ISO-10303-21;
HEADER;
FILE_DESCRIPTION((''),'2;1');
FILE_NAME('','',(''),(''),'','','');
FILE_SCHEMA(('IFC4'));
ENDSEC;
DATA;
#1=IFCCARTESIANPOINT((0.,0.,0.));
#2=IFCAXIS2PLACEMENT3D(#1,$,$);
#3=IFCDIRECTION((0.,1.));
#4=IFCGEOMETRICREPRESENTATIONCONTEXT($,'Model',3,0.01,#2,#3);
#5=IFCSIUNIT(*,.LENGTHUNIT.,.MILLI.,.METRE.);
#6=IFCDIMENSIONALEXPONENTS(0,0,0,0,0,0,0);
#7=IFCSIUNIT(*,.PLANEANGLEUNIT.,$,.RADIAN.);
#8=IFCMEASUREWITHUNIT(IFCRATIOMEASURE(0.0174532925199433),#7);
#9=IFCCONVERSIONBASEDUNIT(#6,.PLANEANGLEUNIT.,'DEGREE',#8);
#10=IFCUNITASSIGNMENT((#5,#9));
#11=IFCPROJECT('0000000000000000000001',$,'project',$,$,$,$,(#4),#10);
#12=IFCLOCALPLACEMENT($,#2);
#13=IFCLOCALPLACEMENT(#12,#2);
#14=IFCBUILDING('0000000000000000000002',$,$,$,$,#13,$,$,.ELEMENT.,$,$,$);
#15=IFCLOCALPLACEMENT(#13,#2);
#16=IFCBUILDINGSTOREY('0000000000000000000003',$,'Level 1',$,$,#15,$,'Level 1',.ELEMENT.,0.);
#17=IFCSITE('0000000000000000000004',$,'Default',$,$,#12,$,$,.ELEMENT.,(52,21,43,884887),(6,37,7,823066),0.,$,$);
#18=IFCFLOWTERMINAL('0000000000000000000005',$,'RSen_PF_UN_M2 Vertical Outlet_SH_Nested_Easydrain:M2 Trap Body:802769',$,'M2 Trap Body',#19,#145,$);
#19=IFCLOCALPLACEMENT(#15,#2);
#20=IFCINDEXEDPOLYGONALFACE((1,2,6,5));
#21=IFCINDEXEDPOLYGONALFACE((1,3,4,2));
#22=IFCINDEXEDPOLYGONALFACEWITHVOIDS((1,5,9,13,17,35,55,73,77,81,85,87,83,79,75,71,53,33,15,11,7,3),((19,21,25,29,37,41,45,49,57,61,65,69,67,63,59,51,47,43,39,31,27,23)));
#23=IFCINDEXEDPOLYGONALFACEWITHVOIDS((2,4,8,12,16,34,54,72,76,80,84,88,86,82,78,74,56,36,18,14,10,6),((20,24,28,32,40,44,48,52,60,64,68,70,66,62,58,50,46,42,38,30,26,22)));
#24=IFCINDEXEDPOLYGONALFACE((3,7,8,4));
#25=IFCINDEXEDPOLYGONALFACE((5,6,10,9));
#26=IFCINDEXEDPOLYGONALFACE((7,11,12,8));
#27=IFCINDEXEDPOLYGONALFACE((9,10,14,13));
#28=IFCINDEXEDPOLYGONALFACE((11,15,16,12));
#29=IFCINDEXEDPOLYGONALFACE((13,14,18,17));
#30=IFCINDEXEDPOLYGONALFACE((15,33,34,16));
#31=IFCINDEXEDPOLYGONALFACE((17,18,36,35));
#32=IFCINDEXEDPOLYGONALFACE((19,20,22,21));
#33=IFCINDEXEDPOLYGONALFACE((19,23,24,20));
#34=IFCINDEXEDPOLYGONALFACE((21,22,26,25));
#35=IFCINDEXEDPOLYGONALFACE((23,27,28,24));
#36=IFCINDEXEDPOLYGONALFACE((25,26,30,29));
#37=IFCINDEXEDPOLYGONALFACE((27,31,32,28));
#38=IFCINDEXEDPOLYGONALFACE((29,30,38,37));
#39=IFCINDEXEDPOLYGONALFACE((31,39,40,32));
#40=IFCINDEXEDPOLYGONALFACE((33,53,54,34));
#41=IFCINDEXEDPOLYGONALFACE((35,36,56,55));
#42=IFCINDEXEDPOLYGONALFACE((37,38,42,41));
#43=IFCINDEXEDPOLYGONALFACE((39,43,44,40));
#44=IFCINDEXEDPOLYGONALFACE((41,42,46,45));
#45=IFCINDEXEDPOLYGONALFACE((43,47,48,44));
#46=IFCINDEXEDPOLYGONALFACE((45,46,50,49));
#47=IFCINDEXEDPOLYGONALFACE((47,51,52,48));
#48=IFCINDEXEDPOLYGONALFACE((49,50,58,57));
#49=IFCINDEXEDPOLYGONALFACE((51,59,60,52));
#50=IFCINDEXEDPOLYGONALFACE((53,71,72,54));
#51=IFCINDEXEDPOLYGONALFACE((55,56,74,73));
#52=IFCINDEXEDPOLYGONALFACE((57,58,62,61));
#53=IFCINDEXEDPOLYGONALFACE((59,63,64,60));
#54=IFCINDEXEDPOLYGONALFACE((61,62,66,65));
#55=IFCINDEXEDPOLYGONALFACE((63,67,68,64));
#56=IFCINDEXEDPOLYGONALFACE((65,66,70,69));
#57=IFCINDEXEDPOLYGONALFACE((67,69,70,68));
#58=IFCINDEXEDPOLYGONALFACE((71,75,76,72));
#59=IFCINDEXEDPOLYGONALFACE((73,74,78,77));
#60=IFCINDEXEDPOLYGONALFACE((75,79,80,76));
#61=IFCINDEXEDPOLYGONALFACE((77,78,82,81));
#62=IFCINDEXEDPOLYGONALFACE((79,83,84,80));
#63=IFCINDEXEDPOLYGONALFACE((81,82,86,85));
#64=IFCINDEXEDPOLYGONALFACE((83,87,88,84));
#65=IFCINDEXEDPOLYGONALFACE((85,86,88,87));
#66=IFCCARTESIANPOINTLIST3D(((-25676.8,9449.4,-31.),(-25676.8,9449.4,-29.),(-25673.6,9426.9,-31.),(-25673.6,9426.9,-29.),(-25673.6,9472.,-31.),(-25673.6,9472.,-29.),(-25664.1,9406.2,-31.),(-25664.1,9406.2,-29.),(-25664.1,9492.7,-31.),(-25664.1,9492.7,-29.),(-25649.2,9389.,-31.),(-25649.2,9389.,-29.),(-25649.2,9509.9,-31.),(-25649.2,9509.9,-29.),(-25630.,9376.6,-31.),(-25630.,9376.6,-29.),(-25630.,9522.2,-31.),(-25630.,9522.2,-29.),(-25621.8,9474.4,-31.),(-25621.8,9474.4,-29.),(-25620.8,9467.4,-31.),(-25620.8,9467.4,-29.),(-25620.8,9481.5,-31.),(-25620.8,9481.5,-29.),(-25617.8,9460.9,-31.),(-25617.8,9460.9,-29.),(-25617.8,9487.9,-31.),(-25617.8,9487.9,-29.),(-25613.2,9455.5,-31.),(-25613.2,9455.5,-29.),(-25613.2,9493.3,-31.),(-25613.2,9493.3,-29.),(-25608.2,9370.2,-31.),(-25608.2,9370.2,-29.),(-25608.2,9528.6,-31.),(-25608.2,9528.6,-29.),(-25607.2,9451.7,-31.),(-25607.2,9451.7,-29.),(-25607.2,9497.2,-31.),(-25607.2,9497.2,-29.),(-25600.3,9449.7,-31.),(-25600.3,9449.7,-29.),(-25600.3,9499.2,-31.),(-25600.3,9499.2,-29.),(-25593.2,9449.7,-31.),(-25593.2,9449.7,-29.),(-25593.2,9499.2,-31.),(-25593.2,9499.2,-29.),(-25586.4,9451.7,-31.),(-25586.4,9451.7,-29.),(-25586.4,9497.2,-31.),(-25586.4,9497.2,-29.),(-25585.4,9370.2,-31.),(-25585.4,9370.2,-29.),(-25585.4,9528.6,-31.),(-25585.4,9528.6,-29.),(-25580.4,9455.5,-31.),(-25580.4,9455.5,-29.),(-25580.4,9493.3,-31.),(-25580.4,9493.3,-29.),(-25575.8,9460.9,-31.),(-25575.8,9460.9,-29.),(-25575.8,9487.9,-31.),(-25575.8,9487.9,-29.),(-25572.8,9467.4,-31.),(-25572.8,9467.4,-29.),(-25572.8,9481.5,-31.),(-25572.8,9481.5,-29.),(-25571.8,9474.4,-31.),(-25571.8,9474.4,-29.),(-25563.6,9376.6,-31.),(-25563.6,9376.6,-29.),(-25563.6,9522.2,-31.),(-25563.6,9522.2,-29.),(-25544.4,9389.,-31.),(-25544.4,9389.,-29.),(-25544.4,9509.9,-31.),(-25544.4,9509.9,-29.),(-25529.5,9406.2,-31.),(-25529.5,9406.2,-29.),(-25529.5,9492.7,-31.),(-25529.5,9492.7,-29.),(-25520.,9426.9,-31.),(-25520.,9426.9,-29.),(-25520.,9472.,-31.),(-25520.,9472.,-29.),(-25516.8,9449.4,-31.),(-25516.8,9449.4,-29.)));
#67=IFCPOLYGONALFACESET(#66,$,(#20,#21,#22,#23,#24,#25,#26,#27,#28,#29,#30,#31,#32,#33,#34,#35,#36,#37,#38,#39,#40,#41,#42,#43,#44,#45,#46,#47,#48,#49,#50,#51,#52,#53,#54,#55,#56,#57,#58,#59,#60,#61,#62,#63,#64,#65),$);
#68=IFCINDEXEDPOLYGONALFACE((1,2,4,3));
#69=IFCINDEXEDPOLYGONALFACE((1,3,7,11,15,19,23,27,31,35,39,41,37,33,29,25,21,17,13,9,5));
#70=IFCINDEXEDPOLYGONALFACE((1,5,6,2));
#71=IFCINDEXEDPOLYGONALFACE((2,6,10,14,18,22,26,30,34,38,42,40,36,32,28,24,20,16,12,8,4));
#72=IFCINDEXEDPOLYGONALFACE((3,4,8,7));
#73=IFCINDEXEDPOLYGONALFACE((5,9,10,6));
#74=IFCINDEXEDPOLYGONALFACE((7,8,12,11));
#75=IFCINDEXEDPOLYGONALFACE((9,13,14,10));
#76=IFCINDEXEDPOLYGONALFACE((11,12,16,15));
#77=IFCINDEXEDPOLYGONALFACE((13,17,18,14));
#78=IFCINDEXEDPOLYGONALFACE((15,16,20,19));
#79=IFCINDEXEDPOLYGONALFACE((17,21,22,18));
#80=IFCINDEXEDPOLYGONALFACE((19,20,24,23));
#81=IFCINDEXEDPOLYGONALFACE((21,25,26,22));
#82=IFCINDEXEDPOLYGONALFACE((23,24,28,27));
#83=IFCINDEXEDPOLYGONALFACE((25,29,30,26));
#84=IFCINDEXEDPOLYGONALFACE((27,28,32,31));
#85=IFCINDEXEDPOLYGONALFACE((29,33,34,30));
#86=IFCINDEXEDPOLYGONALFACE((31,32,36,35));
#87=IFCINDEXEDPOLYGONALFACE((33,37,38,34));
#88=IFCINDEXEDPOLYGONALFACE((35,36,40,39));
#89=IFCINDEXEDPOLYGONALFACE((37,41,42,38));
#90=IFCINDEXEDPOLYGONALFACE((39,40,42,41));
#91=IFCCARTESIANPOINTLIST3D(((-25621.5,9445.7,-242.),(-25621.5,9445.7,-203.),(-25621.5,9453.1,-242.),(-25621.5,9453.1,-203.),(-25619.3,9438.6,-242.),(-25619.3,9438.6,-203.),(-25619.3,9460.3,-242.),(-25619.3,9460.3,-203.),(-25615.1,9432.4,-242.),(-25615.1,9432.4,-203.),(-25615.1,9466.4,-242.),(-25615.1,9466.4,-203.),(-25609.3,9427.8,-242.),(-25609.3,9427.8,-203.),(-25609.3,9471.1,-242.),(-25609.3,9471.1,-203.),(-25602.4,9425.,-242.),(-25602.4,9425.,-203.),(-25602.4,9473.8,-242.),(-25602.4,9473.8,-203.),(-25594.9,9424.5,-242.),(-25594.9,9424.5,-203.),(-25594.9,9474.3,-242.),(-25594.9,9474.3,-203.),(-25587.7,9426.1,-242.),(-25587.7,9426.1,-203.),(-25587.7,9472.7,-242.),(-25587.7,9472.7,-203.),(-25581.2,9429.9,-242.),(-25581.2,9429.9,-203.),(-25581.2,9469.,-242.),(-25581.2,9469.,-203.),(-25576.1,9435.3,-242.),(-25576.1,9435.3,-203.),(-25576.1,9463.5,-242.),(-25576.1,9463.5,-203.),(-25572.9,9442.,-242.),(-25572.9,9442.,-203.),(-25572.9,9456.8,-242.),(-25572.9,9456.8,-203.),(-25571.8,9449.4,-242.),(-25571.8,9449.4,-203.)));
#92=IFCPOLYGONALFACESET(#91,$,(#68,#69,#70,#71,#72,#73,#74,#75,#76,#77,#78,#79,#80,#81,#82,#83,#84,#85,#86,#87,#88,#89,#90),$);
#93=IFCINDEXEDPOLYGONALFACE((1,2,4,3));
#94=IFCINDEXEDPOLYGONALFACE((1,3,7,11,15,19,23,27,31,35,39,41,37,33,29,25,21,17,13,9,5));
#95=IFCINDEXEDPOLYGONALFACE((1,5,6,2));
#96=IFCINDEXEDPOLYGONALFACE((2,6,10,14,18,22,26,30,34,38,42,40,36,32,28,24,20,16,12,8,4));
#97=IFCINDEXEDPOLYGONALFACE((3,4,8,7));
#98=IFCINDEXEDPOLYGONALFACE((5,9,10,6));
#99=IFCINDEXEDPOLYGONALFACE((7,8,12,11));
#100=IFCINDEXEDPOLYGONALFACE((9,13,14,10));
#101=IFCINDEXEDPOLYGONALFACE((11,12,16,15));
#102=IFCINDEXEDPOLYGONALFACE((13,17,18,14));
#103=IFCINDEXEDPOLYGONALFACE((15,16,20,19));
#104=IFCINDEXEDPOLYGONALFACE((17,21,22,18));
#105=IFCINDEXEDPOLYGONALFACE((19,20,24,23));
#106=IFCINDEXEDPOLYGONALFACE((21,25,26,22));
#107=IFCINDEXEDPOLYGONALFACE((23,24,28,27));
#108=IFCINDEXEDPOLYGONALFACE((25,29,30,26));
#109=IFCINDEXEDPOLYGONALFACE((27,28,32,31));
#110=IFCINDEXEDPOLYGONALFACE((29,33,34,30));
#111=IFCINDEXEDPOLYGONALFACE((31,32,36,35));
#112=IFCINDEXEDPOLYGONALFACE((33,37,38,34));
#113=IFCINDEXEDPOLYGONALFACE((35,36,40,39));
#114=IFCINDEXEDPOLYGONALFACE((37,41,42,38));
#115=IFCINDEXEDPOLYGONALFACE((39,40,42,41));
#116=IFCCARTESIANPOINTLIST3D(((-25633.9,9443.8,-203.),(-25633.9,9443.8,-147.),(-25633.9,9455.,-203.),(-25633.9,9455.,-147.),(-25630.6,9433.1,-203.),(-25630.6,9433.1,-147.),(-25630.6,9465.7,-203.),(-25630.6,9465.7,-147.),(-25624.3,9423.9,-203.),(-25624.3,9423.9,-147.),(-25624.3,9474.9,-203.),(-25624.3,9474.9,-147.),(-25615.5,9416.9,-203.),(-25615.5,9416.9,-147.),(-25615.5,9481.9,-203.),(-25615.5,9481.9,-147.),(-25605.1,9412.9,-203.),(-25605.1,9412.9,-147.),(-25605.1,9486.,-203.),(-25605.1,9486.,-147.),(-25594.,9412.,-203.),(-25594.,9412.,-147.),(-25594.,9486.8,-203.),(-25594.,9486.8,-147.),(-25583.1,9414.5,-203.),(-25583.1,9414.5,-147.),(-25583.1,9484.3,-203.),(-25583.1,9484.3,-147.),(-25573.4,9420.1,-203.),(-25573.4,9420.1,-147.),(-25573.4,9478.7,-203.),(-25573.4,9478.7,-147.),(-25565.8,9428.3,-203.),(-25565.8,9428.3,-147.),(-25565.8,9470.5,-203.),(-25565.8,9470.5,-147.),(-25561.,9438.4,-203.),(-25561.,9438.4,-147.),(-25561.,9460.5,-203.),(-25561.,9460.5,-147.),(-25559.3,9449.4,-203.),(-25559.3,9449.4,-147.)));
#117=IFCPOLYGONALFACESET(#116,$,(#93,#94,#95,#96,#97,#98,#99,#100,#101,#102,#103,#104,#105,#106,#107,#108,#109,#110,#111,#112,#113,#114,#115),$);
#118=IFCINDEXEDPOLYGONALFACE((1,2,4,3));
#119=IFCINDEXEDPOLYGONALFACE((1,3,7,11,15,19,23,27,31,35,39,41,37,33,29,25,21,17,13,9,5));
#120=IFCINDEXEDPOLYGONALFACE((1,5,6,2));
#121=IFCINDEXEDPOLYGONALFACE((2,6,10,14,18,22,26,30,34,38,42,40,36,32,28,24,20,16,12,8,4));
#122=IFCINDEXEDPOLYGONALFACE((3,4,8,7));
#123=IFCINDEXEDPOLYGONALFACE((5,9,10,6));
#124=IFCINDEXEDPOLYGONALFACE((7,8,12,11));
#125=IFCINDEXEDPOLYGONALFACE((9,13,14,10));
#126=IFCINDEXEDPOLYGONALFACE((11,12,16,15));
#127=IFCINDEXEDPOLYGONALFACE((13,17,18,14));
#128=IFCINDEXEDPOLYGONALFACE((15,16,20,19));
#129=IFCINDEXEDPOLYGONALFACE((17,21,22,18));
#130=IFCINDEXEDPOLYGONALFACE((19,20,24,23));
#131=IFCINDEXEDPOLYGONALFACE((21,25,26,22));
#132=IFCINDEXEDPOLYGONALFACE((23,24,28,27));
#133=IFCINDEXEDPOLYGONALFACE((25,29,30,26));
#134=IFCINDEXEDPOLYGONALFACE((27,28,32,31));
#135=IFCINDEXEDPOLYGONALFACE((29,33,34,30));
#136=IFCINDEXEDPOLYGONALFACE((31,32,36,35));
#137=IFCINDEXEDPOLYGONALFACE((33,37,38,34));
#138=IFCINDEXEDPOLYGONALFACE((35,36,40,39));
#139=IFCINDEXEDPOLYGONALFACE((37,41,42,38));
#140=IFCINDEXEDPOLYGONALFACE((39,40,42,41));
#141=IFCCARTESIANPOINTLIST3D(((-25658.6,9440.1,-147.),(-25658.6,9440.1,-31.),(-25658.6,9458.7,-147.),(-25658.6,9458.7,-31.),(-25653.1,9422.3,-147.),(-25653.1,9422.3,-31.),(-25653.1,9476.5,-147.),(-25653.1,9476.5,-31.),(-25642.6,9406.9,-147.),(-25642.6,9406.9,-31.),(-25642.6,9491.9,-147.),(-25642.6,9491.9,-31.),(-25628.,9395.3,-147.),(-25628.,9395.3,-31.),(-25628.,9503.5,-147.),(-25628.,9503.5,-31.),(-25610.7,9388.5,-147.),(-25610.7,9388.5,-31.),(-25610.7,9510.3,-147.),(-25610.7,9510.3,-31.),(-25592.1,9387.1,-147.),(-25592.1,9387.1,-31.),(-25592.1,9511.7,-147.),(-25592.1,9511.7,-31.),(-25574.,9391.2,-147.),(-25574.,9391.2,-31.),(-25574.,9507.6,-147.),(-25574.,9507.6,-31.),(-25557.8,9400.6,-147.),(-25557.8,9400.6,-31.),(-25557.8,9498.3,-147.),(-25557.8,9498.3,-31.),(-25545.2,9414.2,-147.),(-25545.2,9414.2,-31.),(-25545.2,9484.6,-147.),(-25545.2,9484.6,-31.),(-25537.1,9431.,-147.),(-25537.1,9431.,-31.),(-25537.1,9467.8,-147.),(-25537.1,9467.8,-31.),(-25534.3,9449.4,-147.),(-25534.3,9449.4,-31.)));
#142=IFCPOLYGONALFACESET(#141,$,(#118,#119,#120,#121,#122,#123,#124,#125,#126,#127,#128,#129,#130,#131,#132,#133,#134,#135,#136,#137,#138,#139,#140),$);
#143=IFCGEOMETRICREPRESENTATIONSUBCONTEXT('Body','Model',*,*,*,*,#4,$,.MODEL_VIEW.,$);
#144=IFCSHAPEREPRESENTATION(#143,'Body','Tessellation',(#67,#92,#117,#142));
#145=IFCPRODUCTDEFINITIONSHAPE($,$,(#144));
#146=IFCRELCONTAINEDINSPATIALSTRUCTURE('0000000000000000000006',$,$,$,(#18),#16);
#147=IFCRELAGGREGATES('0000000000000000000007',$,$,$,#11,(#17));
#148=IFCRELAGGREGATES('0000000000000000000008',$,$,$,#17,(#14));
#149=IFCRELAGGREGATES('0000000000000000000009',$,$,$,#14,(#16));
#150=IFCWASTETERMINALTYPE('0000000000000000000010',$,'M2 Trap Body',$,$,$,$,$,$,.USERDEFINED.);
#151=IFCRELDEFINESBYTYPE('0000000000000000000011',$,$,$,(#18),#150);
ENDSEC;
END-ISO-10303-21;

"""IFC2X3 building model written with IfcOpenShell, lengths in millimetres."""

from ifc_helpers import new_model, entity, si_unit, converted_unit, direction, frame, frame_2d, origin, origin_2d_with_axis, place, context, subcontext, project, spatial, circle_curve, parameter, trimmed, segment, composite_curve, circle, outline, extrude, source, transform, mapped, type_object, type_shapes, element, save


model = new_model("IFC2X3")

# Units and contexts
model_context = context("Model", 3, precision=0.01, world=origin(), true_north=direction((0.0, 1.0)))
body_context = subcontext(model_context, "Body", "Model", "MODEL_VIEW")
ifc_project = project(units=[si_unit("LENGTHUNIT", "METRE", prefix="MILLI"), converted_unit("PLANEANGLEUNIT", "DEGREE", entity("IfcRatioMeasure", 0.0174532925199433), si_unit("PLANEANGLEUNIT", "RADIAN"), dimensions=[0, 0, 0, 0, 0, 0, 0])], contexts=[model_context])

# Site, building, storey
site_placement = place(None, origin())
site = spatial("IfcSite", under=ifc_project, at=site_placement, Name="Default", CompositionType="ELEMENT", RefLatitude=(52, 21, 43, 884887), RefLongitude=(6, 37, 7, 823066), RefElevation=0.0)
building_placement = place(site_placement, origin())
building = spatial("IfcBuilding", under=site, at=building_placement, CompositionType="ELEMENT")
storey_placement = place(building_placement, origin())
storey = spatial("IfcBuildingStorey", under=building, at=storey_placement, Name="Level 1", LongName="Level 1", CompositionType="ELEMENT", Elevation=0.0)

# Flow terminal
waste_terminal_type_1 = type_object("IfcWasteTerminalType", Name="M2 Trap Body", PredefinedType="USERDEFINED")
shared_shape_1 = source(origin(), body_context, "Body", "SweptSolid", [
    extrude(outline(composite_curve([segment(trimmed(circle_curve(origin_2d_with_axis(), 80.0), [parameter(0.0)], [parameter(180.0)], True, "PARAMETER"), True, "CONTINUOUS"), segment(trimmed(circle_curve(origin_2d_with_axis(), 80.0), [parameter(180.0)], [parameter(360.0)], True, "PARAMETER"), True, "CONTINUOUS")], self_intersect=False), holes=[composite_curve([segment(trimmed(circle_curve(frame_2d((0.0, 25.0), x_axis=(1.0, 0.0)), 25.0), [parameter(180.0)], [parameter(360.0)], True, "PARAMETER"), False, "CONTINUOUS"), segment(trimmed(circle_curve(frame_2d((0.0, 25.0), x_axis=(1.0, 0.0)), 25.0), [parameter(0.0)], [parameter(180.0)], True, "PARAMETER"), False, "CONTINUOUS")], self_intersect=False)]), frame((0.0, -25.0, -2.0)), (0.0, 0.0, 1.0), 2.0),
    extrude(circle(Radius=25.0, at=frame_2d((0.0, 0.0), x_axis=(1.0, 0.0))), frame((0.0, -25.0, -213.0)), (0.0, 0.0, 1.0), 39.0),
    extrude(circle(Radius=37.5, at=frame_2d((0.0, 0.0), x_axis=(1.0, 0.0))), frame((0.0, -25.0, -174.0)), (0.0, 0.0, 1.0), 56.0),
    extrude(circle(Radius=62.5, at=frame_2d((0.0, 0.0), x_axis=(1.0, 0.0))), frame((0.0, -25.0, -118.0)), (0.0, 0.0, 1.0), 116.0),
])
type_shapes(waste_terminal_type_1, [shared_shape_1])
for number, where, name in (
    (1, (-25596.8, 9474.4, -29.0), "RSen_PF_UN_M2 Vertical Outlet_SH_Nested_Easydrain:M2 Trap Body:802769"),
):
    element("IfcFlowTerminal", number, at=place(storey_placement, frame(where)), inside=storey, type_object=waste_terminal_type_1, Name=name, ObjectType="M2 Trap Body", context=body_context, shape_type="MappedRepresentation", body=[
        mapped(shared_shape_1, transform((0.0, 0.0, 0.0), scale=1.0)),
    ])

save(model, "model.ifc")
